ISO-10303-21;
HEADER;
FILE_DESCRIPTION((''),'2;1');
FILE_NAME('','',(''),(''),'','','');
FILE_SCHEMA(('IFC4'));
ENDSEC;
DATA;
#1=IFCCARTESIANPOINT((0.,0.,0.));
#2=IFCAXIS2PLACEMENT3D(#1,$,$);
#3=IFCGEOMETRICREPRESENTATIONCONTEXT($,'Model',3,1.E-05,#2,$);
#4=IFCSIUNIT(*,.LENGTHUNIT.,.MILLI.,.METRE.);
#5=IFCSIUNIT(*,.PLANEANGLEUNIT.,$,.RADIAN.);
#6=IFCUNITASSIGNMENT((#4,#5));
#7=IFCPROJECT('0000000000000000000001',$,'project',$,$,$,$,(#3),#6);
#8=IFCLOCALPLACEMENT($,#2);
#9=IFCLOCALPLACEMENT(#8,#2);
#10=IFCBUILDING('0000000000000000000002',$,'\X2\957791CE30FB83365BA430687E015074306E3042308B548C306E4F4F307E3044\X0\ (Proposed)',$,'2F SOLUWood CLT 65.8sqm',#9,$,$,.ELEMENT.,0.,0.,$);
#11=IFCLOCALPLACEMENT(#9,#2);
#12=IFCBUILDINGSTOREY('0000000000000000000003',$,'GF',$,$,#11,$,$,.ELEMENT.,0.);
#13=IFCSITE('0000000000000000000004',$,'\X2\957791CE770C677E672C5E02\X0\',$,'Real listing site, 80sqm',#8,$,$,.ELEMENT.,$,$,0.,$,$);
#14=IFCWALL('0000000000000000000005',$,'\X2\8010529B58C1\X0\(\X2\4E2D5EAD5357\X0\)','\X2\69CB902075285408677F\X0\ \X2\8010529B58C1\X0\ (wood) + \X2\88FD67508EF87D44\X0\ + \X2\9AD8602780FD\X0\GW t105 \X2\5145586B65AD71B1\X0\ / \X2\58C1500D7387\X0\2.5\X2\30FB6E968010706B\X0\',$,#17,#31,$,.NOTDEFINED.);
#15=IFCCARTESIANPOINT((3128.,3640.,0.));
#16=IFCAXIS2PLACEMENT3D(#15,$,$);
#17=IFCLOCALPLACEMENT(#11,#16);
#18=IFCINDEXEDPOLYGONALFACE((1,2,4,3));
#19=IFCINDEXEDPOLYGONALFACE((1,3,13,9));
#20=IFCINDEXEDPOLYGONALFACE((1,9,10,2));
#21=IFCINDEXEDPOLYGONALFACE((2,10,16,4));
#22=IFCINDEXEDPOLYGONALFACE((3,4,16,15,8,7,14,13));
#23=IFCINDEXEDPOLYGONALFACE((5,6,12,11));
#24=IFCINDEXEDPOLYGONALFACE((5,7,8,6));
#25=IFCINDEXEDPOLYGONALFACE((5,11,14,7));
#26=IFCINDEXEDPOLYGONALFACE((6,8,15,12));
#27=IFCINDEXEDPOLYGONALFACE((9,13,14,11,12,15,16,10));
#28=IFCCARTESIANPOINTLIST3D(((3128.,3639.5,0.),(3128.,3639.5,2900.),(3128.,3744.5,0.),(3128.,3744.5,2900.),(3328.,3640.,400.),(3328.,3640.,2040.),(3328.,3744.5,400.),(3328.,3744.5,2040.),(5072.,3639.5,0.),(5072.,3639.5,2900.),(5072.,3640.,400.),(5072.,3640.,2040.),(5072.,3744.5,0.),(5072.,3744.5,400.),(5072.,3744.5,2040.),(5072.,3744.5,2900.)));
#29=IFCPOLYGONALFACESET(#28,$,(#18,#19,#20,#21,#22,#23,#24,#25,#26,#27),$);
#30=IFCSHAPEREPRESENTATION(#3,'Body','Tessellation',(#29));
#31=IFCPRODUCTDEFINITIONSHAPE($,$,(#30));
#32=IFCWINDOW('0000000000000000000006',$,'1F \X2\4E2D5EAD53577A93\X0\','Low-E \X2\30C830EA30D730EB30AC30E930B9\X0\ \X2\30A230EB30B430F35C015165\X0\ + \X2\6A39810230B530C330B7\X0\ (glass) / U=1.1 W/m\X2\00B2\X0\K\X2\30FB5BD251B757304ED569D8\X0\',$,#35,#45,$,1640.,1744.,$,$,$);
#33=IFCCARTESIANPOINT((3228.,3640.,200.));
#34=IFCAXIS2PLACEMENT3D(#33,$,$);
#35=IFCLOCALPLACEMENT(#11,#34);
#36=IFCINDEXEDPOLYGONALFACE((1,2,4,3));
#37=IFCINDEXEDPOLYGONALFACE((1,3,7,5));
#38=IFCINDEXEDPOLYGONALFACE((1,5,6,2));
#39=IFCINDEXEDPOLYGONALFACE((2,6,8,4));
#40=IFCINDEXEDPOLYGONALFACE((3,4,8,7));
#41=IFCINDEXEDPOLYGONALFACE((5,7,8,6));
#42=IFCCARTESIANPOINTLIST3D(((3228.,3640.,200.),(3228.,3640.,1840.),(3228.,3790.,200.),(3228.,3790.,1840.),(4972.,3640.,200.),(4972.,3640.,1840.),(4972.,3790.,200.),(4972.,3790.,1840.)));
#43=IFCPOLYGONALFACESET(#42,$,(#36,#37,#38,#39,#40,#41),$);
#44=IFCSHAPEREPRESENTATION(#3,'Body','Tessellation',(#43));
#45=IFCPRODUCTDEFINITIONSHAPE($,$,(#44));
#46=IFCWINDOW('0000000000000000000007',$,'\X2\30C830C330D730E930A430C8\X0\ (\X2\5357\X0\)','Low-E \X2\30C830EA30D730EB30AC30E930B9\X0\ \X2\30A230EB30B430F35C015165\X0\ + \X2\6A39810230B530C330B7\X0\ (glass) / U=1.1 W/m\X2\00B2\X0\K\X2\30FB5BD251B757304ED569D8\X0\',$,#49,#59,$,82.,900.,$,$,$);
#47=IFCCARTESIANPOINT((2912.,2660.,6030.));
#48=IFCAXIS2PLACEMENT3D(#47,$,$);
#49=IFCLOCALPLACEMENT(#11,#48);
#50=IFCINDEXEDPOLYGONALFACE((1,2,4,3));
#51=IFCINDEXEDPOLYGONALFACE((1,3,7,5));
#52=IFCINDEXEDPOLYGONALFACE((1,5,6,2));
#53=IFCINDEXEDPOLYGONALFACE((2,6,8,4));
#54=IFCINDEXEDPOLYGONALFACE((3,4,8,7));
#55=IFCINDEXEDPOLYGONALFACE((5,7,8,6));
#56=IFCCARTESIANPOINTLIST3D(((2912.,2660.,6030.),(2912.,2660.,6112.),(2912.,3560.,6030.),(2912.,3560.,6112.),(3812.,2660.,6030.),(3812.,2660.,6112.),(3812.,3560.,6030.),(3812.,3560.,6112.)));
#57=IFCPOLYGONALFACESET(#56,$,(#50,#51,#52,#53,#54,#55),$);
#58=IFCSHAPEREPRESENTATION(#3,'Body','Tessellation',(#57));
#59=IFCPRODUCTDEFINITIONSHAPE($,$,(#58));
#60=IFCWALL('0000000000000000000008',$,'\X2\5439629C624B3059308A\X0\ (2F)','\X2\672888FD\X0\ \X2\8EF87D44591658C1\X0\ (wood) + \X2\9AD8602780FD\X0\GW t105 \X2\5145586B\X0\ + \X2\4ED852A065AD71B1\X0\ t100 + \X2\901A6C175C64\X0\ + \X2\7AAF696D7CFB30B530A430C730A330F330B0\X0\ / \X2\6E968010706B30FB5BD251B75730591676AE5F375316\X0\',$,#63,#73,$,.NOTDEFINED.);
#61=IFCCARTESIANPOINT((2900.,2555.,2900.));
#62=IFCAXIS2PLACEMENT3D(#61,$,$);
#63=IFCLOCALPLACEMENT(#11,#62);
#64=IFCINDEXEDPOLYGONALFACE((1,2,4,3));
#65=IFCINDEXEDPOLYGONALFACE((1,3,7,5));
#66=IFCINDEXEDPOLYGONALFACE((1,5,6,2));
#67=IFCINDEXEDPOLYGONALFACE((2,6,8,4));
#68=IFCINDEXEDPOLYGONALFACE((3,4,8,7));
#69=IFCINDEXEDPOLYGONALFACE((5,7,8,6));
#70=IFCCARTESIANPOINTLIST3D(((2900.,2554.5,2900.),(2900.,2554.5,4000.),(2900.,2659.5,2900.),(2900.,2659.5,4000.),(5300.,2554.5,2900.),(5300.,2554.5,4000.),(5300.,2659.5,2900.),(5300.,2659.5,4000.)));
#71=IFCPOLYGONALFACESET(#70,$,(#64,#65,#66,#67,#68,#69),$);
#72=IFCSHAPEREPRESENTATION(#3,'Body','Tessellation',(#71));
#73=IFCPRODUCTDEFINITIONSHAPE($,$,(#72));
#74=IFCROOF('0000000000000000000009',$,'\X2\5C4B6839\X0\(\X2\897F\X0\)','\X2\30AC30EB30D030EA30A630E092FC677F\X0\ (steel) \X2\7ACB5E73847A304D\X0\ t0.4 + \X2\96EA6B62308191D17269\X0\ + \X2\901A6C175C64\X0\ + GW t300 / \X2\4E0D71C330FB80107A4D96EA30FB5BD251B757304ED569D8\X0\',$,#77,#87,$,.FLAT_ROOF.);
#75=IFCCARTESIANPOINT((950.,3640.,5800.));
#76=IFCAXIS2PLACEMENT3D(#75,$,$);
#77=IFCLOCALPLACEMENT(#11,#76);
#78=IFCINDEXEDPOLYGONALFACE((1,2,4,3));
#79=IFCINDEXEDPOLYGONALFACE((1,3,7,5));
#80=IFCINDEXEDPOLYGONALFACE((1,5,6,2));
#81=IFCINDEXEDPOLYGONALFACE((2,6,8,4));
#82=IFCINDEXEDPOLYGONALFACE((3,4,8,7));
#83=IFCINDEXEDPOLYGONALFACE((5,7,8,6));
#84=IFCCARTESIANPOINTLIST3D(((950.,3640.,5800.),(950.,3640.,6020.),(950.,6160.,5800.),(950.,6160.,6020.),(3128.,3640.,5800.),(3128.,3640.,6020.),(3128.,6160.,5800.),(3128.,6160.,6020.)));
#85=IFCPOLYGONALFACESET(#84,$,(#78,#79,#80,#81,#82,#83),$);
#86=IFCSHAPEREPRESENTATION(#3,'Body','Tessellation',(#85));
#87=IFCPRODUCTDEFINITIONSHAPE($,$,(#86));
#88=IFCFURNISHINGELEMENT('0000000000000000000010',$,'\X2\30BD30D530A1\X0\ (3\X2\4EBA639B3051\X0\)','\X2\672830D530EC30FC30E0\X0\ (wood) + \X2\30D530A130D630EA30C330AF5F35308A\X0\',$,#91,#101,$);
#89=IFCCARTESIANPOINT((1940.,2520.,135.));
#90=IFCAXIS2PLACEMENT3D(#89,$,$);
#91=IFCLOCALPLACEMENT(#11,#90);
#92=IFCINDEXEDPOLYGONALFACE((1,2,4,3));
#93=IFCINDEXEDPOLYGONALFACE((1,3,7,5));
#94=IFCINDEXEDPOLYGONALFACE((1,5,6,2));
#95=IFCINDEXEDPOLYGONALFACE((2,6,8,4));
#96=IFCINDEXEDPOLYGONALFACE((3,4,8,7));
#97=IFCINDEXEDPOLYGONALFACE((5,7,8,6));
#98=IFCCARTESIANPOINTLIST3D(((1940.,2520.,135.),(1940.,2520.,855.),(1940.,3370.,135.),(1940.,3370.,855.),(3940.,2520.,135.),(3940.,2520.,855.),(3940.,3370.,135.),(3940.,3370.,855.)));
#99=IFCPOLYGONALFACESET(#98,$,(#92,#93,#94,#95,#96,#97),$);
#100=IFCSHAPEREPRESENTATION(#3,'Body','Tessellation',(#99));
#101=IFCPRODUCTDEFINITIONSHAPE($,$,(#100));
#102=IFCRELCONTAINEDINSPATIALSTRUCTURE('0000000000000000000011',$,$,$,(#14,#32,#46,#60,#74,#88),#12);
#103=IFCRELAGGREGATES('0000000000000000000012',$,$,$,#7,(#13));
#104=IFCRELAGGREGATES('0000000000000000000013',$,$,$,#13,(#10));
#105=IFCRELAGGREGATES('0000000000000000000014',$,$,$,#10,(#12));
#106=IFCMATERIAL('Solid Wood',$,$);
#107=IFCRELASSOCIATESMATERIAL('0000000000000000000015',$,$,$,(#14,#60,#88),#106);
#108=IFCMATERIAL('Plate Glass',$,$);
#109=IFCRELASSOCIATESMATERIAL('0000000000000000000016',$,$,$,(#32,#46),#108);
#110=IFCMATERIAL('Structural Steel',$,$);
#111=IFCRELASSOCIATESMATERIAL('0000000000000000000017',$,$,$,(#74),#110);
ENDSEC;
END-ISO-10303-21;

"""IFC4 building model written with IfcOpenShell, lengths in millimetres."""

from ifc_helpers import new_model, si_unit, frame, frame_2d, origin, place, context, project, spatial, rectangle, extrude, material, element, fill, save


model = new_model("IFC4")

# Units and contexts
model_context = context("Model", 3, precision=1e-05, world=origin())
ifc_project = project(units=[si_unit("LENGTHUNIT", "METRE", prefix="MILLI"), si_unit("PLANEANGLEUNIT", "RADIAN")], contexts=[model_context])

# Site, building, storey
site_placement = place(None, origin())
site = spatial("IfcSite", under=ifc_project, at=site_placement, Name="長野県松本市", ObjectType="Real listing site, 80sqm", CompositionType="ELEMENT", RefElevation=0.0)
building_placement = place(site_placement, origin())
building = spatial("IfcBuilding", under=site, at=building_placement, Name="長野・茶室と縁側のある和の住まい (Proposed)", ObjectType="2F SOLUWood CLT 65.8sqm", CompositionType="ELEMENT", ElevationOfRefHeight=0.0, ElevationOfTerrain=0.0)
storey_placement = place(building_placement, origin())
storey = spatial("IfcBuildingStorey", under=building, at=storey_placement, Name="GF", CompositionType="ELEMENT", Elevation=0.0)

# Shared definitions
ifc_material_1 = material(Name="Solid Wood")

# Wall, opening, window
wall_1_placement = place(storey_placement, frame((3128.0, 3640.0, 0.0)))
wall_1 = element("IfcWall", 1, at=wall_1_placement, inside=storey, material=ifc_material_1, Name="耐力壁(中庭南)", Description="構造用合板 耐力壁 (wood) + 製材軸組 + 高性能GW t105 充填断熱 / 壁倍率2.5・準耐火", PredefinedType="NOTDEFINED", context=model_context, shape_type="SweptSolid", body=[
    extrude(rectangle(XDim=1944.0, YDim=105.0, at=frame_2d((972.0, 52.0))), frame((3128.0, 3640.0, 0.0)), (0.0, 0.0, 1.0), 2900.0),
])
opening_placement = place(storey_placement, frame((3228.0, 3640.0, 200.0)))
opening = element("IfcOpeningElement", 2, at=opening_placement, cuts=wall_1, PredefinedType="NOTDEFINED", context=model_context, shape_type="SweptSolid", body=[
    extrude(rectangle(XDim=1744.0, YDim=150.0, at=frame_2d((872.0, 75.0))), frame((3228.0, 3640.0, 200.0)), (0.0, 0.0, 1.0), 1640.0),
])
ifc_material_2 = material(Name="Plate Glass")
window_1_placement = place(storey_placement, frame((3228.0, 3640.0, 200.0)))
window_1 = element("IfcWindow", 3, at=window_1_placement, inside=storey, material=ifc_material_2, Name="1F 中庭南窓", Description="Low-E トリプルガラス アルゴン封入 + 樹脂サッシ (glass) / U=1.1 W/m²K・寒冷地仕様", OverallHeight=1640.0, OverallWidth=1744.0, context=model_context, shape_type="SweptSolid", body=[
    extrude(rectangle(XDim=1744.0, YDim=150.0, at=frame_2d((872.0, 75.0))), frame((3228.0, 3640.0, 200.0)), (0.0, 0.0, 1.0), 1640.0),
])
fill(opening, window_1)

# Window
window_2_placement = place(storey_placement, frame((2912.0, 2660.0, 6030.0)))
element("IfcWindow", 4, at=window_2_placement, inside=storey, material=ifc_material_2, Name="トップライト (南)", Description="Low-E トリプルガラス アルゴン封入 + 樹脂サッシ (glass) / U=1.1 W/m²K・寒冷地仕様", OverallHeight=82.0, OverallWidth=900.0, context=model_context, shape_type="SweptSolid", body=[
    extrude(rectangle(XDim=900.0, YDim=900.0, at=frame_2d((450.0, 450.0))), frame((2912.0, 2660.0, 6030.0)), (0.0, 0.0, 1.0), 82.0),
])

# Wall
wall_2_placement = place(storey_placement, frame((2900.0, 2555.0, 2900.0)))
element("IfcWall", 5, at=wall_2_placement, inside=storey, material=ifc_material_1, Name="吹抜手すり (2F)", Description="木製 軸組外壁 (wood) + 高性能GW t105 充填 + 付加断熱 t100 + 通気層 + 窯業系サイディング / 準耐火・寒冷地外皮強化", PredefinedType="NOTDEFINED", context=model_context, shape_type="SweptSolid", body=[
    extrude(rectangle(XDim=2400.0, YDim=105.0, at=frame_2d((1200.0, 52.0))), frame((2900.0, 2555.0, 2900.0)), (0.0, 0.0, 1.0), 1100.0),
])

# Roof
ifc_material_3 = material(Name="Structural Steel")
for number, where, name in (
    (6, (950.0, 3640.0, 5800.0), "屋根(西)"),
):
    element("IfcRoof", number, at=place(storey_placement, frame(where)), inside=storey, material=ifc_material_3, Name=name, Description="ガルバリウム鋼板 (steel) 立平葺き t0.4 + 雪止め金物 + 通気層 + GW t300 / 不燃・耐積雪・寒冷地仕様", PredefinedType="FLAT_ROOF", context=model_context, shape_type="SweptSolid", body=[
        extrude(rectangle(XDim=2178.0, YDim=2520.0, at=frame_2d((1089.0, 1260.0))), frame((950.0, 3640.0, 5800.0)), (0.0, 0.0, 1.0), 220.0),
    ])

# Furnishing element
furnishing_placement = place(storey_placement, frame((1940.0, 2520.0, 135.0)))
element("IfcFurnishingElement", 7, at=furnishing_placement, inside=storey, material=ifc_material_1, Name="ソファ (3人掛け)", Description="木フレーム (wood) + ファブリック張り", context=model_context, shape_type="SweptSolid", body=[
    extrude(rectangle(XDim=2000.0, YDim=850.0, at=frame_2d((1000.0, 425.0))), frame((1940.0, 2520.0, 135.0)), (0.0, 0.0, 1.0), 720.0),
])

save(model, "model.ifc")
